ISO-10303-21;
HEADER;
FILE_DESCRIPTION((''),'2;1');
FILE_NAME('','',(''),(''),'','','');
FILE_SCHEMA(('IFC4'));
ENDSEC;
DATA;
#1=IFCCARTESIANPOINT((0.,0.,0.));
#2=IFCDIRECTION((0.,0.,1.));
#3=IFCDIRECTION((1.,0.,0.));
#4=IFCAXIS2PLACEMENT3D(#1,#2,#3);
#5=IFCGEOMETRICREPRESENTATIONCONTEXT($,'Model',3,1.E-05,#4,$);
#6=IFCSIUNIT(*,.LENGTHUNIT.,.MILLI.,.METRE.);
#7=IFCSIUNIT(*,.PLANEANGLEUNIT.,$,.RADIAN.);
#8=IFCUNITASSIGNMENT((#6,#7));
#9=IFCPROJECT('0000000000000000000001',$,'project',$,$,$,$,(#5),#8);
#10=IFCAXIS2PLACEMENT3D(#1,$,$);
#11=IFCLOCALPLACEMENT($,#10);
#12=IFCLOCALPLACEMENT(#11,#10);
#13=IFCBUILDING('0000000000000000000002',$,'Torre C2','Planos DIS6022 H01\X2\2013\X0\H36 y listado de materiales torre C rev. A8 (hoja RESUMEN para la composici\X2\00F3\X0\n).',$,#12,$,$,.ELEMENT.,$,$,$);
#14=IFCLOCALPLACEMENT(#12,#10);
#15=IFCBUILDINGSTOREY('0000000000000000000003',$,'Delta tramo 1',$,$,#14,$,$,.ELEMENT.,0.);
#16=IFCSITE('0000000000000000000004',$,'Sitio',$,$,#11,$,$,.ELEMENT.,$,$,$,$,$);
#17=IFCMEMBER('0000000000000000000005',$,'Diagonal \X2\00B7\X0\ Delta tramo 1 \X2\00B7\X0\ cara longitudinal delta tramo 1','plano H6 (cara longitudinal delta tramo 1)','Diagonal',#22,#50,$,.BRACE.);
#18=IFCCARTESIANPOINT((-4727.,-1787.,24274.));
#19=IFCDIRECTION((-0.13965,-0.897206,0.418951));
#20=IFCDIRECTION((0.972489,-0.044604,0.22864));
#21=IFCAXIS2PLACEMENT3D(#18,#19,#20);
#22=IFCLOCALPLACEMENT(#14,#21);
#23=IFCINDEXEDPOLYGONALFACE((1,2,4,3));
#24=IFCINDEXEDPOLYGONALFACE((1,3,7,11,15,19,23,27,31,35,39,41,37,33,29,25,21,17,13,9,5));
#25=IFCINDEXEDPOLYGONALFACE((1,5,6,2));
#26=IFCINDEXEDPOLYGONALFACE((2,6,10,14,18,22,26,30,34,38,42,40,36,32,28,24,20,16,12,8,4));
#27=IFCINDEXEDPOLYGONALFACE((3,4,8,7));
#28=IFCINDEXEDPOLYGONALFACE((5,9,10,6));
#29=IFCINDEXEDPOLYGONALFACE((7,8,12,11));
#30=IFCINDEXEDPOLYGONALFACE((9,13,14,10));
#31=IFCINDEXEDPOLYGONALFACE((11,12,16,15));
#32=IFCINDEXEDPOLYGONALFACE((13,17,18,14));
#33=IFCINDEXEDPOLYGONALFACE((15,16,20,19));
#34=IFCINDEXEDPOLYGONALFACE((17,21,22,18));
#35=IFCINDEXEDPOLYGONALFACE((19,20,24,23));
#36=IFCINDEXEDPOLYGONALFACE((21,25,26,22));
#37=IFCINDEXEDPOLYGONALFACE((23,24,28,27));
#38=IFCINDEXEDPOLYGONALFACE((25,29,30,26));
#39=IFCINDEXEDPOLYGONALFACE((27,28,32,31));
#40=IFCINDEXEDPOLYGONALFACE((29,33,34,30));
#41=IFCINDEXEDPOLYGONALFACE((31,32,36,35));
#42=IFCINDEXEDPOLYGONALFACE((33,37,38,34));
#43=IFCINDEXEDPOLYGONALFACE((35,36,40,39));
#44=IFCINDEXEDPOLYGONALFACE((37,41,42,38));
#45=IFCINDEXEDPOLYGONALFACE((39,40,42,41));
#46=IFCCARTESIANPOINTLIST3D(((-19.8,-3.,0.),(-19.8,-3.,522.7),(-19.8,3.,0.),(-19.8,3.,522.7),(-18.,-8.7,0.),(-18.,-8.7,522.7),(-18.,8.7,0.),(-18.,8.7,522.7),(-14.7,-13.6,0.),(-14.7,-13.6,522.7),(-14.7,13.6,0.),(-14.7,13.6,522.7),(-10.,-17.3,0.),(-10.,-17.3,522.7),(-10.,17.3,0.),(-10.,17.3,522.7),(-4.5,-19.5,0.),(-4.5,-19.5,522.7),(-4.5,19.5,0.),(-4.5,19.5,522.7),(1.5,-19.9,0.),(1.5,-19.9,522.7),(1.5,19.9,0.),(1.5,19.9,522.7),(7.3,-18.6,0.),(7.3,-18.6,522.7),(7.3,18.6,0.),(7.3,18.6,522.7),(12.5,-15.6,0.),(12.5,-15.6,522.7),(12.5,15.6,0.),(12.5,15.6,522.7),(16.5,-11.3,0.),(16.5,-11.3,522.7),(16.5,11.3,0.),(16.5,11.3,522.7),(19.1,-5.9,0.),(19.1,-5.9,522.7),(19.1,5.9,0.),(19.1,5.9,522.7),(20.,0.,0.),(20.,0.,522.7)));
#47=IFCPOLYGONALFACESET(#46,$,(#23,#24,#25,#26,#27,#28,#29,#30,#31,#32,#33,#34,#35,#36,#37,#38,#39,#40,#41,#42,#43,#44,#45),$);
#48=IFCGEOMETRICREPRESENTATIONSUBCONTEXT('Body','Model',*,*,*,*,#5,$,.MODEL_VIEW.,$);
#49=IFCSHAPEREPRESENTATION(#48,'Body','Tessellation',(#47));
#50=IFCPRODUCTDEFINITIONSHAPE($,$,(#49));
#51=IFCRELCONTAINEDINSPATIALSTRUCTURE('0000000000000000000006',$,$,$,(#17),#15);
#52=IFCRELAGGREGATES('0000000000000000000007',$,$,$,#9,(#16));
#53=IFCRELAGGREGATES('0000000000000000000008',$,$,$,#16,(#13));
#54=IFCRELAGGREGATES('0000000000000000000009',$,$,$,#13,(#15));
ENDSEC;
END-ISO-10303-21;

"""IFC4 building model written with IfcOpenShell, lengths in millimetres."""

from ifc_helpers import new_model, si_unit, frame, origin, origin_with_axes, place, context, subcontext, project, spatial, circle, extrude, element, save


model = new_model("IFC4")

# Units and contexts
model_context = context("Model", 3, precision=1e-05, world=origin_with_axes())
body_context = subcontext(model_context, "Body", "Model", "MODEL_VIEW")
ifc_project = project(units=[si_unit("LENGTHUNIT", "METRE", prefix="MILLI"), si_unit("PLANEANGLEUNIT", "RADIAN")], contexts=[model_context])

# Site, building, storey
site_placement = place(None, origin())
site = spatial("IfcSite", under=ifc_project, at=site_placement, Name="Sitio", CompositionType="ELEMENT")
building_placement = place(site_placement, origin())
building = spatial("IfcBuilding", under=site, at=building_placement, Name="Torre C2", Description="Planos DIS6022 H01–H36 y listado de materiales torre C rev. A8 (hoja RESUMEN para la composición).", CompositionType="ELEMENT")
storey_placement = place(building_placement, origin())
storey = spatial("IfcBuildingStorey", under=building, at=storey_placement, Name="Delta tramo 1", CompositionType="ELEMENT", Elevation=0.0)

# Member
member_1_placement = place(storey_placement, frame((-4727.0, -1787.0, 24274.0), z_axis=(-0.13965, -0.897206, 0.418951), x_axis=(0.972489, -0.044604, 0.22864)))
element("IfcMember", 1, at=member_1_placement, inside=storey, Name="Diagonal · Delta tramo 1 · cara longitudinal delta tramo 1", Description="plano H6 (cara longitudinal delta tramo 1)", ObjectType="Diagonal", PredefinedType="BRACE", context=body_context, shape_type="SweptSolid", body=[
    extrude(circle(Radius=20.0), None, (0.0, 0.0, 1.0), 522.7),
])

save(model, "model.ifc")
